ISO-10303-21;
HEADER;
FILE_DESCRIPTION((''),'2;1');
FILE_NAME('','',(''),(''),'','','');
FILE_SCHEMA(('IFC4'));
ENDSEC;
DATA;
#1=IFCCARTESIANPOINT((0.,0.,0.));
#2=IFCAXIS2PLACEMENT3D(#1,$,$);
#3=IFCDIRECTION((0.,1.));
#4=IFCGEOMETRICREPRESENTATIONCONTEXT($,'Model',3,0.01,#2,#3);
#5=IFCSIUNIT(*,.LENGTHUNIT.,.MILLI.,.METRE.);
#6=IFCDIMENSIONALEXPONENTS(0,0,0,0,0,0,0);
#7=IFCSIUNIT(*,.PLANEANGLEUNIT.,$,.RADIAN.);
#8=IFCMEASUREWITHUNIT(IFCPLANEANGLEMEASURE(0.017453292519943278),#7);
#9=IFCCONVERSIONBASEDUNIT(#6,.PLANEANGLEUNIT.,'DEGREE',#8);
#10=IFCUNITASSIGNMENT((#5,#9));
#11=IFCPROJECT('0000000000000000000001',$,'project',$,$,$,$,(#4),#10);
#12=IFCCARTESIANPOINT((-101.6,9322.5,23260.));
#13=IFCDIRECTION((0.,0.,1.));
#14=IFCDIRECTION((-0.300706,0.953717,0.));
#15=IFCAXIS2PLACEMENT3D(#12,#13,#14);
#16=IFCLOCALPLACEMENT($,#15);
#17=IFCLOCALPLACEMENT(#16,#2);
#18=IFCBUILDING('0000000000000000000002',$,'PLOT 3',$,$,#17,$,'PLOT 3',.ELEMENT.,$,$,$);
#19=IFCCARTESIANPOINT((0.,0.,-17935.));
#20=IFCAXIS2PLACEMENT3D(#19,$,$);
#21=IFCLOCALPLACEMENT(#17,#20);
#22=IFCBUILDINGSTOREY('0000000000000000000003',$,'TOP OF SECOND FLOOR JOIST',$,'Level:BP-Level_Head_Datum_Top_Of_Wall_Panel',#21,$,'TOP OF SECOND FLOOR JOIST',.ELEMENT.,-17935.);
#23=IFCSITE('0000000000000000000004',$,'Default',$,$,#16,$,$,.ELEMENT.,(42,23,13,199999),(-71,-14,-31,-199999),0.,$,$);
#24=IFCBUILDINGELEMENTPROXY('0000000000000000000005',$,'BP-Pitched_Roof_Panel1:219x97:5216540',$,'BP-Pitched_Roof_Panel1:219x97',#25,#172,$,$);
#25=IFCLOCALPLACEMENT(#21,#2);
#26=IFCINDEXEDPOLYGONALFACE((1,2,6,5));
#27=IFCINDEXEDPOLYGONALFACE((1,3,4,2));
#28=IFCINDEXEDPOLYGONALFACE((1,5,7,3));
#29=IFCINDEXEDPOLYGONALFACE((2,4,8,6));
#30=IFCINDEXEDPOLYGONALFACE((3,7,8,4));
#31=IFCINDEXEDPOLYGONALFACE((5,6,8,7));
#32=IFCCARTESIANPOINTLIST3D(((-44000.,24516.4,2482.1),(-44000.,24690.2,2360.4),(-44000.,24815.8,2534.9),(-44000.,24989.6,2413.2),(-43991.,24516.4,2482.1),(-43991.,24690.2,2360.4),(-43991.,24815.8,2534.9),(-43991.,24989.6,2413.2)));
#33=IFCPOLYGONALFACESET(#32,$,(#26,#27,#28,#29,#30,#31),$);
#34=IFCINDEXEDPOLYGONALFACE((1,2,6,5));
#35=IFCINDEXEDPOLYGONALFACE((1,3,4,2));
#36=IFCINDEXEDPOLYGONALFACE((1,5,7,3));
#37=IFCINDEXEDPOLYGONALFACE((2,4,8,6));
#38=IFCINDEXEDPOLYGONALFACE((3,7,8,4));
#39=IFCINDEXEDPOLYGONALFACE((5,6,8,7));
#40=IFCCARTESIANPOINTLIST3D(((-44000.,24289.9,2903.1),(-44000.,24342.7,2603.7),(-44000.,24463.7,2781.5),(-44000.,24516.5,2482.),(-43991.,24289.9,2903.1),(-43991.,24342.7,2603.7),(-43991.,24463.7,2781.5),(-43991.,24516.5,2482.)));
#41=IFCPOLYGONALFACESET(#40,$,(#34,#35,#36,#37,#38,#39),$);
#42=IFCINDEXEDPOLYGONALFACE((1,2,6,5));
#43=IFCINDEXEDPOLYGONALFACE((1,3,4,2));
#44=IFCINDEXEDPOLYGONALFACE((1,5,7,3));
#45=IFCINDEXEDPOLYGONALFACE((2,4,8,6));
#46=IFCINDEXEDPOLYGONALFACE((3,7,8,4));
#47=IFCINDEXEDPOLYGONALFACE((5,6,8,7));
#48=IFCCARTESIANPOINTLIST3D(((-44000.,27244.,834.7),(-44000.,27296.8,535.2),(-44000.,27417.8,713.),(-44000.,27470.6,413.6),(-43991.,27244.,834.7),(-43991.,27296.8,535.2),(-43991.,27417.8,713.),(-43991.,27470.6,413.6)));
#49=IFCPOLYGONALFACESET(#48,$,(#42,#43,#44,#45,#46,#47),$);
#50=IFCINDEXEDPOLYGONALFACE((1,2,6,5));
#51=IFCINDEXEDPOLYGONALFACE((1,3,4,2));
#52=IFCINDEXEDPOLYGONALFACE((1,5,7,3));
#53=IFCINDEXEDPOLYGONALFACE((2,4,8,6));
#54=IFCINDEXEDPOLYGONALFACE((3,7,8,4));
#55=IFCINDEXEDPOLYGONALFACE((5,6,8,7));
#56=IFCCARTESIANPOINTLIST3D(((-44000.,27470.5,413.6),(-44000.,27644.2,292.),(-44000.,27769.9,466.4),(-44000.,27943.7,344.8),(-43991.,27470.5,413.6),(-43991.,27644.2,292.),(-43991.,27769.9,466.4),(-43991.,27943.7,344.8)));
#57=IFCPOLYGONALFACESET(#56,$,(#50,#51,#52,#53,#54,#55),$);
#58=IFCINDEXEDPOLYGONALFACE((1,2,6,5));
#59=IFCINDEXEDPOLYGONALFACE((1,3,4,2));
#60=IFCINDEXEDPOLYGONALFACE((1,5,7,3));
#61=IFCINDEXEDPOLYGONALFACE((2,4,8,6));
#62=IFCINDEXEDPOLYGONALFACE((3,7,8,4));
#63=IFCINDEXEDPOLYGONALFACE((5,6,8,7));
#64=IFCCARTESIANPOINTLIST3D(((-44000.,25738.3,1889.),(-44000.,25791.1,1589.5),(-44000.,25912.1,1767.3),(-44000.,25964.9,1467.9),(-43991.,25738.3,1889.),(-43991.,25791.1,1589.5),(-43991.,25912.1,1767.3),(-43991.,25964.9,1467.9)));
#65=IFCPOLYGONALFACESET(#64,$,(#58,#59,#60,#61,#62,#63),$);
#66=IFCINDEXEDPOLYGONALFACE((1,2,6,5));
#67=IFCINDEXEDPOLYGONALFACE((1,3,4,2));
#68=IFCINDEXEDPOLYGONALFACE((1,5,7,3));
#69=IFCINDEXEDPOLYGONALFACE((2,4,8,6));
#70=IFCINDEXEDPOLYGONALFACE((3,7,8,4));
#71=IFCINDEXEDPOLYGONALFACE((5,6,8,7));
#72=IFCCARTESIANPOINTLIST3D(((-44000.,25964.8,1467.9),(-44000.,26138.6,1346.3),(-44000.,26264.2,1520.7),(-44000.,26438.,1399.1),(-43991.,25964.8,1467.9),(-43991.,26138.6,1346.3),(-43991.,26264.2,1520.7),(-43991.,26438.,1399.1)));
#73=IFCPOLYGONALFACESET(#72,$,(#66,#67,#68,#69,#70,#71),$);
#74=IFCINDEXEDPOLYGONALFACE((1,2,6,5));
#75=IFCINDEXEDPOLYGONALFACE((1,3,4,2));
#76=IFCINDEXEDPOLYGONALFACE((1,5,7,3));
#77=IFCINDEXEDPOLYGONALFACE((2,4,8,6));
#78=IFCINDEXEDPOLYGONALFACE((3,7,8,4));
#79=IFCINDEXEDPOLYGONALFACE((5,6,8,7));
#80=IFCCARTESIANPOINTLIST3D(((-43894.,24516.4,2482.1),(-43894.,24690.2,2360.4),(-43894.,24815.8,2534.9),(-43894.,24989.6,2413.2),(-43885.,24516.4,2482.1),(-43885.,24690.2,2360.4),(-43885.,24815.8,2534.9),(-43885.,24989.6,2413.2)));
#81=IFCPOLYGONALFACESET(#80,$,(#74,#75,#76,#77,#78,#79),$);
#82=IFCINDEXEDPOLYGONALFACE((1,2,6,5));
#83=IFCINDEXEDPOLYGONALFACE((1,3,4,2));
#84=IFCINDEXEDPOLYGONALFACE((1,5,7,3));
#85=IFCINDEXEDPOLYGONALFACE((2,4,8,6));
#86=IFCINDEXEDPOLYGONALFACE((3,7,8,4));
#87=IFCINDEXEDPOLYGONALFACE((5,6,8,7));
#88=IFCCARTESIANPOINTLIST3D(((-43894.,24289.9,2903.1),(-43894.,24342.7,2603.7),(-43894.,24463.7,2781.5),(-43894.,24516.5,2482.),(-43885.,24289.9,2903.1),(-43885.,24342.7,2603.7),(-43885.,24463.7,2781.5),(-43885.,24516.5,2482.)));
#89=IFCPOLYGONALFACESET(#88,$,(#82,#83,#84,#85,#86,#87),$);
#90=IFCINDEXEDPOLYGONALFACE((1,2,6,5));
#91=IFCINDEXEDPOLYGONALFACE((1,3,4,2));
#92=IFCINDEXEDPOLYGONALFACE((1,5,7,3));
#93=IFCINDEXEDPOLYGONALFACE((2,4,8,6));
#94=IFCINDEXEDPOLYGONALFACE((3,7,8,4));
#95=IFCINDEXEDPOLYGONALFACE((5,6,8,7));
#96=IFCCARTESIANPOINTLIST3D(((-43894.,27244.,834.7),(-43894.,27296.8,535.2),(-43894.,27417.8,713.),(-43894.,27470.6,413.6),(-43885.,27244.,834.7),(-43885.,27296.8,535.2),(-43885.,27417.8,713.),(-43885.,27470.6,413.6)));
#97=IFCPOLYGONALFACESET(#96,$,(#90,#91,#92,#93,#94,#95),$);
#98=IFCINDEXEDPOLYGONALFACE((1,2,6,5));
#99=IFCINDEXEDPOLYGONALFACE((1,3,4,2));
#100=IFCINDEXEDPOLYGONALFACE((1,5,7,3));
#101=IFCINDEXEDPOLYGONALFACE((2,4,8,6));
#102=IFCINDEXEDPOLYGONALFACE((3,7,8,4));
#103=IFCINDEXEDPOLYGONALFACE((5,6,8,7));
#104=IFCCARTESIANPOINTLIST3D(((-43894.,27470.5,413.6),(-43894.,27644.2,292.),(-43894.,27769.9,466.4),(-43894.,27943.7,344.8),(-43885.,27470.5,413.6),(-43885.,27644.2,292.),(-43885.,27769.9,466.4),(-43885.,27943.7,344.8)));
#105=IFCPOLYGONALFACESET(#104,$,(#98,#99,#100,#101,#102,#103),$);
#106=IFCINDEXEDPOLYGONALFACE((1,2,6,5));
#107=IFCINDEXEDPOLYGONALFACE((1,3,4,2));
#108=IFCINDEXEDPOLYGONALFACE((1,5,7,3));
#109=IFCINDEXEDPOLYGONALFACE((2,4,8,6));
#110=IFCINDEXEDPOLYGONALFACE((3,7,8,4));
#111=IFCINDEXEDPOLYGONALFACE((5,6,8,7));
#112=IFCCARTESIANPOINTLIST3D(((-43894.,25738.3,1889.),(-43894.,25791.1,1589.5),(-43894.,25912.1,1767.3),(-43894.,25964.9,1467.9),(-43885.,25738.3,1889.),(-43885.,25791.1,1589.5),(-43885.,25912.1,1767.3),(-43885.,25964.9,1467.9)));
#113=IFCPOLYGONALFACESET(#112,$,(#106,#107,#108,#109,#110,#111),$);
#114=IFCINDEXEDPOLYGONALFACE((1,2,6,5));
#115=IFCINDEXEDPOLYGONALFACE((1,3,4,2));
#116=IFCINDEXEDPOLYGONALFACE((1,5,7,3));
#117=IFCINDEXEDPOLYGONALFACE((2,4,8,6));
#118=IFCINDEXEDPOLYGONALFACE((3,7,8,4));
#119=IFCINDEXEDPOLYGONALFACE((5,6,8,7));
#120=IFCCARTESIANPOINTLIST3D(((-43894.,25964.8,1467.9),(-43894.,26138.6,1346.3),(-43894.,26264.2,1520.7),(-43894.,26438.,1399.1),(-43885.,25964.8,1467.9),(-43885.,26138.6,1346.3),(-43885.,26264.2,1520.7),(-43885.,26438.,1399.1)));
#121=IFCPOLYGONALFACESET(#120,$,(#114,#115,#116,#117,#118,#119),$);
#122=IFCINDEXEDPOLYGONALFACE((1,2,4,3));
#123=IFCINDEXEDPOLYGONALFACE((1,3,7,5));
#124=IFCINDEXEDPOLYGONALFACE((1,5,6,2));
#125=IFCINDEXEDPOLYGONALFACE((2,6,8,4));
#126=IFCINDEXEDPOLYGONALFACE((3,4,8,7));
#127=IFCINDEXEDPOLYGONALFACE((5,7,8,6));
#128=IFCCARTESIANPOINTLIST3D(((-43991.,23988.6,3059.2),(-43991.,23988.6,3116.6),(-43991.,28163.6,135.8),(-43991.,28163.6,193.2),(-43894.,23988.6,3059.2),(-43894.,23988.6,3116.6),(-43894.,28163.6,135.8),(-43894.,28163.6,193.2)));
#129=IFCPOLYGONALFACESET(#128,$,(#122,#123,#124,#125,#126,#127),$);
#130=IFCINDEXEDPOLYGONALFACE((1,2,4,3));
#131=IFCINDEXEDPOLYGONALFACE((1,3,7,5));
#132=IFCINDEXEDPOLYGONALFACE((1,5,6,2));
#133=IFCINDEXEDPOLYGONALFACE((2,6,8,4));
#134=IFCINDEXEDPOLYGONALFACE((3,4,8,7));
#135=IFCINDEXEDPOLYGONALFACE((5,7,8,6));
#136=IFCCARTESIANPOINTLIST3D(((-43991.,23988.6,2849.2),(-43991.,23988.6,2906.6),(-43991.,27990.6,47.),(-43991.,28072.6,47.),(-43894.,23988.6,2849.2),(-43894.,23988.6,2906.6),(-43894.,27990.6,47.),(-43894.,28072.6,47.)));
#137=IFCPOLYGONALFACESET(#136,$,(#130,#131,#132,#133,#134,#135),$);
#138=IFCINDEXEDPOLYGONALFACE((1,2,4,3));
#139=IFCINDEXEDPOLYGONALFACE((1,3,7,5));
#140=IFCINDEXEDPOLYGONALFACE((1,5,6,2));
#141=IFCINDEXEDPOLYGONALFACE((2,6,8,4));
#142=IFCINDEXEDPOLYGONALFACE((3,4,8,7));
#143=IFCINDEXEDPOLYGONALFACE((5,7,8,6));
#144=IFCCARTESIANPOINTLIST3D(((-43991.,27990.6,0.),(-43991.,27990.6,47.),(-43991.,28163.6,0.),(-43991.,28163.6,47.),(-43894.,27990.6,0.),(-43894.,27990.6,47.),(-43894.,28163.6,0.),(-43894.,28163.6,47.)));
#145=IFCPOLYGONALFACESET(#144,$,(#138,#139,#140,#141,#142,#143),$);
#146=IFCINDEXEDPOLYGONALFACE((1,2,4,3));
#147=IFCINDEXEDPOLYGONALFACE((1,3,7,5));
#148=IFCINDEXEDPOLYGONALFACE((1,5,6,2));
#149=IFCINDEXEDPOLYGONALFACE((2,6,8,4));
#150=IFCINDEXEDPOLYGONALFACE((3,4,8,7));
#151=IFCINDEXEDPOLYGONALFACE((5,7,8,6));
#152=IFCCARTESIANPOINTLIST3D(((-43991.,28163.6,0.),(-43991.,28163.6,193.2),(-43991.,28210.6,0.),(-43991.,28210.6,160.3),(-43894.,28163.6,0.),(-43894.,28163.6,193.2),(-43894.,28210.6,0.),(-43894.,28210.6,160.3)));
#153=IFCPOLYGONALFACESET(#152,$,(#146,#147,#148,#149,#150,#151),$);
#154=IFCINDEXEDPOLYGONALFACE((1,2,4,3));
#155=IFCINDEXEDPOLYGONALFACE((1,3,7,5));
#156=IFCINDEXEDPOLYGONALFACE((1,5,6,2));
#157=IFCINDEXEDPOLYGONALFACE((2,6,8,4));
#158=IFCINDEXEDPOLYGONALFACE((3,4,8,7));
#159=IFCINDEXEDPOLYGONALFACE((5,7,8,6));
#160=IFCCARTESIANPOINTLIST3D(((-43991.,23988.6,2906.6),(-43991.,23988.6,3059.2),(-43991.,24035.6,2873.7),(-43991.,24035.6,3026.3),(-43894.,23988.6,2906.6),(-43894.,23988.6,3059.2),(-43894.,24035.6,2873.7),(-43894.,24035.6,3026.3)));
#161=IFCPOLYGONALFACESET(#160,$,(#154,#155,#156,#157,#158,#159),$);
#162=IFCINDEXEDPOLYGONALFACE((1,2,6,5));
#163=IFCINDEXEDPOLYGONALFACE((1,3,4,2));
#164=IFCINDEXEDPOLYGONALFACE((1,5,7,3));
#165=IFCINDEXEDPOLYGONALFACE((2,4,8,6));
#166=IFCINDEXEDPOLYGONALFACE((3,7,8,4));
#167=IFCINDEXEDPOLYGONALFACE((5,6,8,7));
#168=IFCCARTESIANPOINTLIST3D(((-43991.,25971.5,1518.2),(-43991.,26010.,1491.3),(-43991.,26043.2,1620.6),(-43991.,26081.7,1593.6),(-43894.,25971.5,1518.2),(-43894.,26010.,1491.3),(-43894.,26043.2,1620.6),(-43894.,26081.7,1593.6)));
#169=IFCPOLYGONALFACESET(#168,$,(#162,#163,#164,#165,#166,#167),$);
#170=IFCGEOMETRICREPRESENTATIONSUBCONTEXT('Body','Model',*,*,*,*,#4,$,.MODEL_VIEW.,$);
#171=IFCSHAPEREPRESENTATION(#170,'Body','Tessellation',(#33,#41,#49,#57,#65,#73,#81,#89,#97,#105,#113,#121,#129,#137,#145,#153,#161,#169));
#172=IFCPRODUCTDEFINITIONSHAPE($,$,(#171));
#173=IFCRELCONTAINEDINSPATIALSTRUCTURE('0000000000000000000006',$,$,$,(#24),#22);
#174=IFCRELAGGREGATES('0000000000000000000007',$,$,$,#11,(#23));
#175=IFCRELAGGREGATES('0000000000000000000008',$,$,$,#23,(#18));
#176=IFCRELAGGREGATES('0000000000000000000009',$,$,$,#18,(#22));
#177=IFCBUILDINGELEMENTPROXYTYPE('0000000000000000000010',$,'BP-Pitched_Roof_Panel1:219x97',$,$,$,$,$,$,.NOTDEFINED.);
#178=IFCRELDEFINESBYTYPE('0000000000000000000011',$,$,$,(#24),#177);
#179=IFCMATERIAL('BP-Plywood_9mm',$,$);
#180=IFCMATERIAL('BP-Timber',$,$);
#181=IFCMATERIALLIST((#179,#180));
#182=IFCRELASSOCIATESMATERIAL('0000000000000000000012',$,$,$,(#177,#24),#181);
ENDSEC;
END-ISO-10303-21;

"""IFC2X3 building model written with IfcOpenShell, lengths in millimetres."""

from ifc_helpers import new_model, entity, si_unit, converted_unit, direction, frame, frame_2d, origin, origin_2d_with_axis, place, context, subcontext, project, spatial, polyline, rectangle, outline, extrude, source, transform, mapped, material, material_list, type_object, type_shapes, element, save


model = new_model("IFC2X3")

# Units and contexts
model_context = context("Model", 3, precision=0.01, world=origin(), true_north=direction((0.0, 1.0)))
body_context = subcontext(model_context, "Body", "Model", "MODEL_VIEW")
ifc_project = project(units=[si_unit("LENGTHUNIT", "METRE", prefix="MILLI"), converted_unit("PLANEANGLEUNIT", "DEGREE", entity("IfcPlaneAngleMeasure", 0.017453292519943278), si_unit("PLANEANGLEUNIT", "RADIAN"), dimensions=[0, 0, 0, 0, 0, 0, 0])], contexts=[model_context])

# Site, building, storey
site_placement = place(None, frame((-101.6, 9322.5, 23260.0), z_axis=(0.0, 0.0, 1.0), x_axis=(-0.300706, 0.953717, 0.0)))
site = spatial("IfcSite", under=ifc_project, at=site_placement, Name="Default", CompositionType="ELEMENT", RefLatitude=(42, 23, 13, 199999), RefLongitude=(-71, -14, -31, -199999), RefElevation=0.0)
building_placement = place(site_placement, origin())
building = spatial("IfcBuilding", under=site, at=building_placement, Name="PLOT 3", LongName="PLOT 3", CompositionType="ELEMENT")
storey_placement = place(building_placement, frame((0.0, 0.0, -17935.0)))
storey = spatial("IfcBuildingStorey", under=building, at=storey_placement, Name="TOP OF SECOND FLOOR JOIST", ObjectType="Level:BP-Level_Head_Datum_Top_Of_Wall_Panel", LongName="TOP OF SECOND FLOOR JOIST", CompositionType="ELEMENT", Elevation=-17935.0)

# Building element proxy
ifc_material_1 = material(Name="BP-Timber")
ifc_material_2 = material(Name="BP-Plywood_9mm")
ifc_material_list = material_list([ifc_material_2, ifc_material_1])
building_element_proxy_type_1 = type_object("IfcBuildingElementProxyType", Name="BP-Pitched_Roof_Panel1:219x97", PredefinedType="NOTDEFINED", material=ifc_material_list)
shared_shape_1 = source(origin(), body_context, "Body", "SweptSolid", [
    extrude(outline(polyline([(-77.0, -75.0), (227.0, -75.0), (77.0, 75.0), (-227.0, 75.0), (-77.0, -75.0)])), frame((35.3, -3956.0, 2447.7), z_axis=(0.0, 1.0, 0.0), x_axis=(-0.984808, 0.0, 0.173648)), (0.0, 0.0, 1.0), 9.0),
    extrude(outline(polyline([(1.4, -107.5), (213.6, -107.5), (-1.4, 107.5), (-213.6, 107.5), (1.4, -107.5)])), frame((385.1, -3956.0, 2692.6), z_axis=(0.0, 1.0, 0.0), x_axis=(-0.819152, 0.0, -0.573576)), (0.0, 0.0, 1.0), 9.0),
    extrude(outline(polyline([(1.4, -107.5), (213.6, -107.5), (-1.4, 107.5), (-213.6, 107.5), (1.4, -107.5)])), frame((-2569.0, -3956.0, 624.1), z_axis=(0.0, 1.0, 0.0), x_axis=(-0.819152, 0.0, -0.573576)), (0.0, 0.0, 1.0), 9.0),
    extrude(outline(polyline([(-77.0, -75.0), (227.0, -75.0), (77.0, 75.0), (-227.0, 75.0), (-77.0, -75.0)])), frame((-2918.8, -3956.0, 379.2), z_axis=(0.0, 1.0, 0.0), x_axis=(-0.984808, 0.0, 0.173648)), (0.0, 0.0, 1.0), 9.0),
    extrude(outline(polyline([(1.4, -107.5), (213.6, -107.5), (-1.4, 107.5), (-213.6, 107.5), (1.4, -107.5)])), frame((-1063.3, -3956.0, 1678.4), z_axis=(0.0, 1.0, 0.0), x_axis=(-0.819152, 0.0, -0.573576)), (0.0, 0.0, 1.0), 9.0),
    extrude(outline(polyline([(-77.0, -75.0), (227.0, -75.0), (77.0, 75.0), (-227.0, 75.0), (-77.0, -75.0)])), frame((-1413.1, -3956.0, 1433.5), z_axis=(0.0, 1.0, 0.0), x_axis=(-0.984808, 0.0, 0.173648)), (0.0, 0.0, 1.0), 9.0),
    extrude(outline(polyline([(-77.0, -75.0), (227.0, -75.0), (77.0, 75.0), (-227.0, 75.0), (-77.0, -75.0)])), frame((35.3, -3850.0, 2447.7), z_axis=(0.0, 1.0, 0.0), x_axis=(-0.984808, 0.0, 0.173648)), (0.0, 0.0, 1.0), 9.0),
    extrude(outline(polyline([(1.4, -107.5), (213.6, -107.5), (-1.4, 107.5), (-213.6, 107.5), (1.4, -107.5)])), frame((385.1, -3850.0, 2692.6), z_axis=(0.0, 1.0, 0.0), x_axis=(-0.819152, 0.0, -0.573576)), (0.0, 0.0, 1.0), 9.0),
    extrude(outline(polyline([(1.4, -107.5), (213.6, -107.5), (-1.4, 107.5), (-213.6, 107.5), (1.4, -107.5)])), frame((-2569.0, -3850.0, 624.1), z_axis=(0.0, 1.0, 0.0), x_axis=(-0.819152, 0.0, -0.573576)), (0.0, 0.0, 1.0), 9.0),
    extrude(outline(polyline([(-77.0, -75.0), (227.0, -75.0), (77.0, 75.0), (-227.0, 75.0), (-77.0, -75.0)])), frame((-2918.8, -3850.0, 379.2), z_axis=(0.0, 1.0, 0.0), x_axis=(-0.984808, 0.0, 0.173648)), (0.0, 0.0, 1.0), 9.0),
    extrude(outline(polyline([(1.4, -107.5), (213.6, -107.5), (-1.4, 107.5), (-213.6, 107.5), (1.4, -107.5)])), frame((-1063.3, -3850.0, 1678.4), z_axis=(0.0, 1.0, 0.0), x_axis=(-0.819152, 0.0, -0.573576)), (0.0, 0.0, 1.0), 9.0),
    extrude(outline(polyline([(-77.0, -75.0), (227.0, -75.0), (77.0, 75.0), (-227.0, 75.0), (-77.0, -75.0)])), frame((-1413.1, -3850.0, 1433.5), z_axis=(0.0, 1.0, 0.0), x_axis=(-0.984808, 0.0, 0.173648)), (0.0, 0.0, 1.0), 9.0),
    extrude(outline(polyline([(-1490.4, -2087.5), (-1433.0, -2087.5), (1490.4, 2087.5), (1433.0, 2087.5), (-1490.4, -2087.5)])), frame((-1287.8, -3947.0, 1626.2), z_axis=(0.0, 1.0, 0.0), x_axis=(0.0, 0.0, -1.0)), (0.0, 0.0, 1.0), 97.0),
    extrude(outline(polyline([(-1444.1, -2021.5), (-1386.8, -2021.5), (1415.5, 1980.5), (1415.5, 2062.5), (-1444.1, -2021.5)])), frame((-1221.8, -3947.0, 1462.5), z_axis=(0.0, 1.0, 0.0), x_axis=(0.0, 0.0, -1.0)), (0.0, 0.0, 1.0), 97.0),
    extrude(rectangle(XDim=173.0, YDim=97.0, at=origin_2d_with_axis()), frame((-3288.8, -3898.5, 0.0), z_axis=(0.0, 0.0, 1.0), x_axis=(-1.0, 0.0, 0.0)), (0.0, 0.0, 1.0), 47.0),
    extrude(outline(polyline([(22.0, -72.4), (79.4, -72.4), (-31.4, 85.9), (-69.9, 58.9), (22.0, -72.4)])), frame((-3398.8, -3947.0, 88.4), z_axis=(0.0, 1.0, 0.0), x_axis=(0.819152, 0.0, 0.573576)), (0.0, 0.0, 1.0), 97.0),
    extrude(outline(polyline([(15.1, -62.5), (72.5, -62.5), (-15.1, 62.5), (-72.5, 62.5), (15.1, -62.5)])), frame((776.2, -3947.0, 2966.5), z_axis=(0.0, 1.0, 0.0), x_axis=(0.819152, 0.0, 0.573576)), (0.0, 0.0, 1.0), 97.0),
    extrude(rectangle(XDim=47.0, YDim=97.0, at=frame_2d((0.0, 0.0), x_axis=(1.0, 0.0))), frame((-1202.4, -3898.5, 1504.7), z_axis=(-0.573576, 0.0, 0.819152), x_axis=(-0.819152, 0.0, -0.573576)), (0.0, 0.0, 1.0), 125.0),
])
type_shapes(building_element_proxy_type_1, [shared_shape_1])
for number, where, z_axis, x_axis, name in (
    (1, (-40044.0, 24788.3, 0.0), (0.0, 0.0, 1.0), (0.0, -1.0, 0.0), "BP-Pitched_Roof_Panel1:219x97:5216540"),
):
    element("IfcBuildingElementProxy", number, at=place(storey_placement, frame(where, z_axis=z_axis, x_axis=x_axis)), inside=storey, type_object=building_element_proxy_type_1, material=ifc_material_list, Name=name, ObjectType="BP-Pitched_Roof_Panel1:219x97", context=body_context, shape_type="MappedRepresentation", body=[
        mapped(shared_shape_1, transform((0.0, 0.0, 0.0), scale=1.0)),
    ])

save(model, "model.ifc")
